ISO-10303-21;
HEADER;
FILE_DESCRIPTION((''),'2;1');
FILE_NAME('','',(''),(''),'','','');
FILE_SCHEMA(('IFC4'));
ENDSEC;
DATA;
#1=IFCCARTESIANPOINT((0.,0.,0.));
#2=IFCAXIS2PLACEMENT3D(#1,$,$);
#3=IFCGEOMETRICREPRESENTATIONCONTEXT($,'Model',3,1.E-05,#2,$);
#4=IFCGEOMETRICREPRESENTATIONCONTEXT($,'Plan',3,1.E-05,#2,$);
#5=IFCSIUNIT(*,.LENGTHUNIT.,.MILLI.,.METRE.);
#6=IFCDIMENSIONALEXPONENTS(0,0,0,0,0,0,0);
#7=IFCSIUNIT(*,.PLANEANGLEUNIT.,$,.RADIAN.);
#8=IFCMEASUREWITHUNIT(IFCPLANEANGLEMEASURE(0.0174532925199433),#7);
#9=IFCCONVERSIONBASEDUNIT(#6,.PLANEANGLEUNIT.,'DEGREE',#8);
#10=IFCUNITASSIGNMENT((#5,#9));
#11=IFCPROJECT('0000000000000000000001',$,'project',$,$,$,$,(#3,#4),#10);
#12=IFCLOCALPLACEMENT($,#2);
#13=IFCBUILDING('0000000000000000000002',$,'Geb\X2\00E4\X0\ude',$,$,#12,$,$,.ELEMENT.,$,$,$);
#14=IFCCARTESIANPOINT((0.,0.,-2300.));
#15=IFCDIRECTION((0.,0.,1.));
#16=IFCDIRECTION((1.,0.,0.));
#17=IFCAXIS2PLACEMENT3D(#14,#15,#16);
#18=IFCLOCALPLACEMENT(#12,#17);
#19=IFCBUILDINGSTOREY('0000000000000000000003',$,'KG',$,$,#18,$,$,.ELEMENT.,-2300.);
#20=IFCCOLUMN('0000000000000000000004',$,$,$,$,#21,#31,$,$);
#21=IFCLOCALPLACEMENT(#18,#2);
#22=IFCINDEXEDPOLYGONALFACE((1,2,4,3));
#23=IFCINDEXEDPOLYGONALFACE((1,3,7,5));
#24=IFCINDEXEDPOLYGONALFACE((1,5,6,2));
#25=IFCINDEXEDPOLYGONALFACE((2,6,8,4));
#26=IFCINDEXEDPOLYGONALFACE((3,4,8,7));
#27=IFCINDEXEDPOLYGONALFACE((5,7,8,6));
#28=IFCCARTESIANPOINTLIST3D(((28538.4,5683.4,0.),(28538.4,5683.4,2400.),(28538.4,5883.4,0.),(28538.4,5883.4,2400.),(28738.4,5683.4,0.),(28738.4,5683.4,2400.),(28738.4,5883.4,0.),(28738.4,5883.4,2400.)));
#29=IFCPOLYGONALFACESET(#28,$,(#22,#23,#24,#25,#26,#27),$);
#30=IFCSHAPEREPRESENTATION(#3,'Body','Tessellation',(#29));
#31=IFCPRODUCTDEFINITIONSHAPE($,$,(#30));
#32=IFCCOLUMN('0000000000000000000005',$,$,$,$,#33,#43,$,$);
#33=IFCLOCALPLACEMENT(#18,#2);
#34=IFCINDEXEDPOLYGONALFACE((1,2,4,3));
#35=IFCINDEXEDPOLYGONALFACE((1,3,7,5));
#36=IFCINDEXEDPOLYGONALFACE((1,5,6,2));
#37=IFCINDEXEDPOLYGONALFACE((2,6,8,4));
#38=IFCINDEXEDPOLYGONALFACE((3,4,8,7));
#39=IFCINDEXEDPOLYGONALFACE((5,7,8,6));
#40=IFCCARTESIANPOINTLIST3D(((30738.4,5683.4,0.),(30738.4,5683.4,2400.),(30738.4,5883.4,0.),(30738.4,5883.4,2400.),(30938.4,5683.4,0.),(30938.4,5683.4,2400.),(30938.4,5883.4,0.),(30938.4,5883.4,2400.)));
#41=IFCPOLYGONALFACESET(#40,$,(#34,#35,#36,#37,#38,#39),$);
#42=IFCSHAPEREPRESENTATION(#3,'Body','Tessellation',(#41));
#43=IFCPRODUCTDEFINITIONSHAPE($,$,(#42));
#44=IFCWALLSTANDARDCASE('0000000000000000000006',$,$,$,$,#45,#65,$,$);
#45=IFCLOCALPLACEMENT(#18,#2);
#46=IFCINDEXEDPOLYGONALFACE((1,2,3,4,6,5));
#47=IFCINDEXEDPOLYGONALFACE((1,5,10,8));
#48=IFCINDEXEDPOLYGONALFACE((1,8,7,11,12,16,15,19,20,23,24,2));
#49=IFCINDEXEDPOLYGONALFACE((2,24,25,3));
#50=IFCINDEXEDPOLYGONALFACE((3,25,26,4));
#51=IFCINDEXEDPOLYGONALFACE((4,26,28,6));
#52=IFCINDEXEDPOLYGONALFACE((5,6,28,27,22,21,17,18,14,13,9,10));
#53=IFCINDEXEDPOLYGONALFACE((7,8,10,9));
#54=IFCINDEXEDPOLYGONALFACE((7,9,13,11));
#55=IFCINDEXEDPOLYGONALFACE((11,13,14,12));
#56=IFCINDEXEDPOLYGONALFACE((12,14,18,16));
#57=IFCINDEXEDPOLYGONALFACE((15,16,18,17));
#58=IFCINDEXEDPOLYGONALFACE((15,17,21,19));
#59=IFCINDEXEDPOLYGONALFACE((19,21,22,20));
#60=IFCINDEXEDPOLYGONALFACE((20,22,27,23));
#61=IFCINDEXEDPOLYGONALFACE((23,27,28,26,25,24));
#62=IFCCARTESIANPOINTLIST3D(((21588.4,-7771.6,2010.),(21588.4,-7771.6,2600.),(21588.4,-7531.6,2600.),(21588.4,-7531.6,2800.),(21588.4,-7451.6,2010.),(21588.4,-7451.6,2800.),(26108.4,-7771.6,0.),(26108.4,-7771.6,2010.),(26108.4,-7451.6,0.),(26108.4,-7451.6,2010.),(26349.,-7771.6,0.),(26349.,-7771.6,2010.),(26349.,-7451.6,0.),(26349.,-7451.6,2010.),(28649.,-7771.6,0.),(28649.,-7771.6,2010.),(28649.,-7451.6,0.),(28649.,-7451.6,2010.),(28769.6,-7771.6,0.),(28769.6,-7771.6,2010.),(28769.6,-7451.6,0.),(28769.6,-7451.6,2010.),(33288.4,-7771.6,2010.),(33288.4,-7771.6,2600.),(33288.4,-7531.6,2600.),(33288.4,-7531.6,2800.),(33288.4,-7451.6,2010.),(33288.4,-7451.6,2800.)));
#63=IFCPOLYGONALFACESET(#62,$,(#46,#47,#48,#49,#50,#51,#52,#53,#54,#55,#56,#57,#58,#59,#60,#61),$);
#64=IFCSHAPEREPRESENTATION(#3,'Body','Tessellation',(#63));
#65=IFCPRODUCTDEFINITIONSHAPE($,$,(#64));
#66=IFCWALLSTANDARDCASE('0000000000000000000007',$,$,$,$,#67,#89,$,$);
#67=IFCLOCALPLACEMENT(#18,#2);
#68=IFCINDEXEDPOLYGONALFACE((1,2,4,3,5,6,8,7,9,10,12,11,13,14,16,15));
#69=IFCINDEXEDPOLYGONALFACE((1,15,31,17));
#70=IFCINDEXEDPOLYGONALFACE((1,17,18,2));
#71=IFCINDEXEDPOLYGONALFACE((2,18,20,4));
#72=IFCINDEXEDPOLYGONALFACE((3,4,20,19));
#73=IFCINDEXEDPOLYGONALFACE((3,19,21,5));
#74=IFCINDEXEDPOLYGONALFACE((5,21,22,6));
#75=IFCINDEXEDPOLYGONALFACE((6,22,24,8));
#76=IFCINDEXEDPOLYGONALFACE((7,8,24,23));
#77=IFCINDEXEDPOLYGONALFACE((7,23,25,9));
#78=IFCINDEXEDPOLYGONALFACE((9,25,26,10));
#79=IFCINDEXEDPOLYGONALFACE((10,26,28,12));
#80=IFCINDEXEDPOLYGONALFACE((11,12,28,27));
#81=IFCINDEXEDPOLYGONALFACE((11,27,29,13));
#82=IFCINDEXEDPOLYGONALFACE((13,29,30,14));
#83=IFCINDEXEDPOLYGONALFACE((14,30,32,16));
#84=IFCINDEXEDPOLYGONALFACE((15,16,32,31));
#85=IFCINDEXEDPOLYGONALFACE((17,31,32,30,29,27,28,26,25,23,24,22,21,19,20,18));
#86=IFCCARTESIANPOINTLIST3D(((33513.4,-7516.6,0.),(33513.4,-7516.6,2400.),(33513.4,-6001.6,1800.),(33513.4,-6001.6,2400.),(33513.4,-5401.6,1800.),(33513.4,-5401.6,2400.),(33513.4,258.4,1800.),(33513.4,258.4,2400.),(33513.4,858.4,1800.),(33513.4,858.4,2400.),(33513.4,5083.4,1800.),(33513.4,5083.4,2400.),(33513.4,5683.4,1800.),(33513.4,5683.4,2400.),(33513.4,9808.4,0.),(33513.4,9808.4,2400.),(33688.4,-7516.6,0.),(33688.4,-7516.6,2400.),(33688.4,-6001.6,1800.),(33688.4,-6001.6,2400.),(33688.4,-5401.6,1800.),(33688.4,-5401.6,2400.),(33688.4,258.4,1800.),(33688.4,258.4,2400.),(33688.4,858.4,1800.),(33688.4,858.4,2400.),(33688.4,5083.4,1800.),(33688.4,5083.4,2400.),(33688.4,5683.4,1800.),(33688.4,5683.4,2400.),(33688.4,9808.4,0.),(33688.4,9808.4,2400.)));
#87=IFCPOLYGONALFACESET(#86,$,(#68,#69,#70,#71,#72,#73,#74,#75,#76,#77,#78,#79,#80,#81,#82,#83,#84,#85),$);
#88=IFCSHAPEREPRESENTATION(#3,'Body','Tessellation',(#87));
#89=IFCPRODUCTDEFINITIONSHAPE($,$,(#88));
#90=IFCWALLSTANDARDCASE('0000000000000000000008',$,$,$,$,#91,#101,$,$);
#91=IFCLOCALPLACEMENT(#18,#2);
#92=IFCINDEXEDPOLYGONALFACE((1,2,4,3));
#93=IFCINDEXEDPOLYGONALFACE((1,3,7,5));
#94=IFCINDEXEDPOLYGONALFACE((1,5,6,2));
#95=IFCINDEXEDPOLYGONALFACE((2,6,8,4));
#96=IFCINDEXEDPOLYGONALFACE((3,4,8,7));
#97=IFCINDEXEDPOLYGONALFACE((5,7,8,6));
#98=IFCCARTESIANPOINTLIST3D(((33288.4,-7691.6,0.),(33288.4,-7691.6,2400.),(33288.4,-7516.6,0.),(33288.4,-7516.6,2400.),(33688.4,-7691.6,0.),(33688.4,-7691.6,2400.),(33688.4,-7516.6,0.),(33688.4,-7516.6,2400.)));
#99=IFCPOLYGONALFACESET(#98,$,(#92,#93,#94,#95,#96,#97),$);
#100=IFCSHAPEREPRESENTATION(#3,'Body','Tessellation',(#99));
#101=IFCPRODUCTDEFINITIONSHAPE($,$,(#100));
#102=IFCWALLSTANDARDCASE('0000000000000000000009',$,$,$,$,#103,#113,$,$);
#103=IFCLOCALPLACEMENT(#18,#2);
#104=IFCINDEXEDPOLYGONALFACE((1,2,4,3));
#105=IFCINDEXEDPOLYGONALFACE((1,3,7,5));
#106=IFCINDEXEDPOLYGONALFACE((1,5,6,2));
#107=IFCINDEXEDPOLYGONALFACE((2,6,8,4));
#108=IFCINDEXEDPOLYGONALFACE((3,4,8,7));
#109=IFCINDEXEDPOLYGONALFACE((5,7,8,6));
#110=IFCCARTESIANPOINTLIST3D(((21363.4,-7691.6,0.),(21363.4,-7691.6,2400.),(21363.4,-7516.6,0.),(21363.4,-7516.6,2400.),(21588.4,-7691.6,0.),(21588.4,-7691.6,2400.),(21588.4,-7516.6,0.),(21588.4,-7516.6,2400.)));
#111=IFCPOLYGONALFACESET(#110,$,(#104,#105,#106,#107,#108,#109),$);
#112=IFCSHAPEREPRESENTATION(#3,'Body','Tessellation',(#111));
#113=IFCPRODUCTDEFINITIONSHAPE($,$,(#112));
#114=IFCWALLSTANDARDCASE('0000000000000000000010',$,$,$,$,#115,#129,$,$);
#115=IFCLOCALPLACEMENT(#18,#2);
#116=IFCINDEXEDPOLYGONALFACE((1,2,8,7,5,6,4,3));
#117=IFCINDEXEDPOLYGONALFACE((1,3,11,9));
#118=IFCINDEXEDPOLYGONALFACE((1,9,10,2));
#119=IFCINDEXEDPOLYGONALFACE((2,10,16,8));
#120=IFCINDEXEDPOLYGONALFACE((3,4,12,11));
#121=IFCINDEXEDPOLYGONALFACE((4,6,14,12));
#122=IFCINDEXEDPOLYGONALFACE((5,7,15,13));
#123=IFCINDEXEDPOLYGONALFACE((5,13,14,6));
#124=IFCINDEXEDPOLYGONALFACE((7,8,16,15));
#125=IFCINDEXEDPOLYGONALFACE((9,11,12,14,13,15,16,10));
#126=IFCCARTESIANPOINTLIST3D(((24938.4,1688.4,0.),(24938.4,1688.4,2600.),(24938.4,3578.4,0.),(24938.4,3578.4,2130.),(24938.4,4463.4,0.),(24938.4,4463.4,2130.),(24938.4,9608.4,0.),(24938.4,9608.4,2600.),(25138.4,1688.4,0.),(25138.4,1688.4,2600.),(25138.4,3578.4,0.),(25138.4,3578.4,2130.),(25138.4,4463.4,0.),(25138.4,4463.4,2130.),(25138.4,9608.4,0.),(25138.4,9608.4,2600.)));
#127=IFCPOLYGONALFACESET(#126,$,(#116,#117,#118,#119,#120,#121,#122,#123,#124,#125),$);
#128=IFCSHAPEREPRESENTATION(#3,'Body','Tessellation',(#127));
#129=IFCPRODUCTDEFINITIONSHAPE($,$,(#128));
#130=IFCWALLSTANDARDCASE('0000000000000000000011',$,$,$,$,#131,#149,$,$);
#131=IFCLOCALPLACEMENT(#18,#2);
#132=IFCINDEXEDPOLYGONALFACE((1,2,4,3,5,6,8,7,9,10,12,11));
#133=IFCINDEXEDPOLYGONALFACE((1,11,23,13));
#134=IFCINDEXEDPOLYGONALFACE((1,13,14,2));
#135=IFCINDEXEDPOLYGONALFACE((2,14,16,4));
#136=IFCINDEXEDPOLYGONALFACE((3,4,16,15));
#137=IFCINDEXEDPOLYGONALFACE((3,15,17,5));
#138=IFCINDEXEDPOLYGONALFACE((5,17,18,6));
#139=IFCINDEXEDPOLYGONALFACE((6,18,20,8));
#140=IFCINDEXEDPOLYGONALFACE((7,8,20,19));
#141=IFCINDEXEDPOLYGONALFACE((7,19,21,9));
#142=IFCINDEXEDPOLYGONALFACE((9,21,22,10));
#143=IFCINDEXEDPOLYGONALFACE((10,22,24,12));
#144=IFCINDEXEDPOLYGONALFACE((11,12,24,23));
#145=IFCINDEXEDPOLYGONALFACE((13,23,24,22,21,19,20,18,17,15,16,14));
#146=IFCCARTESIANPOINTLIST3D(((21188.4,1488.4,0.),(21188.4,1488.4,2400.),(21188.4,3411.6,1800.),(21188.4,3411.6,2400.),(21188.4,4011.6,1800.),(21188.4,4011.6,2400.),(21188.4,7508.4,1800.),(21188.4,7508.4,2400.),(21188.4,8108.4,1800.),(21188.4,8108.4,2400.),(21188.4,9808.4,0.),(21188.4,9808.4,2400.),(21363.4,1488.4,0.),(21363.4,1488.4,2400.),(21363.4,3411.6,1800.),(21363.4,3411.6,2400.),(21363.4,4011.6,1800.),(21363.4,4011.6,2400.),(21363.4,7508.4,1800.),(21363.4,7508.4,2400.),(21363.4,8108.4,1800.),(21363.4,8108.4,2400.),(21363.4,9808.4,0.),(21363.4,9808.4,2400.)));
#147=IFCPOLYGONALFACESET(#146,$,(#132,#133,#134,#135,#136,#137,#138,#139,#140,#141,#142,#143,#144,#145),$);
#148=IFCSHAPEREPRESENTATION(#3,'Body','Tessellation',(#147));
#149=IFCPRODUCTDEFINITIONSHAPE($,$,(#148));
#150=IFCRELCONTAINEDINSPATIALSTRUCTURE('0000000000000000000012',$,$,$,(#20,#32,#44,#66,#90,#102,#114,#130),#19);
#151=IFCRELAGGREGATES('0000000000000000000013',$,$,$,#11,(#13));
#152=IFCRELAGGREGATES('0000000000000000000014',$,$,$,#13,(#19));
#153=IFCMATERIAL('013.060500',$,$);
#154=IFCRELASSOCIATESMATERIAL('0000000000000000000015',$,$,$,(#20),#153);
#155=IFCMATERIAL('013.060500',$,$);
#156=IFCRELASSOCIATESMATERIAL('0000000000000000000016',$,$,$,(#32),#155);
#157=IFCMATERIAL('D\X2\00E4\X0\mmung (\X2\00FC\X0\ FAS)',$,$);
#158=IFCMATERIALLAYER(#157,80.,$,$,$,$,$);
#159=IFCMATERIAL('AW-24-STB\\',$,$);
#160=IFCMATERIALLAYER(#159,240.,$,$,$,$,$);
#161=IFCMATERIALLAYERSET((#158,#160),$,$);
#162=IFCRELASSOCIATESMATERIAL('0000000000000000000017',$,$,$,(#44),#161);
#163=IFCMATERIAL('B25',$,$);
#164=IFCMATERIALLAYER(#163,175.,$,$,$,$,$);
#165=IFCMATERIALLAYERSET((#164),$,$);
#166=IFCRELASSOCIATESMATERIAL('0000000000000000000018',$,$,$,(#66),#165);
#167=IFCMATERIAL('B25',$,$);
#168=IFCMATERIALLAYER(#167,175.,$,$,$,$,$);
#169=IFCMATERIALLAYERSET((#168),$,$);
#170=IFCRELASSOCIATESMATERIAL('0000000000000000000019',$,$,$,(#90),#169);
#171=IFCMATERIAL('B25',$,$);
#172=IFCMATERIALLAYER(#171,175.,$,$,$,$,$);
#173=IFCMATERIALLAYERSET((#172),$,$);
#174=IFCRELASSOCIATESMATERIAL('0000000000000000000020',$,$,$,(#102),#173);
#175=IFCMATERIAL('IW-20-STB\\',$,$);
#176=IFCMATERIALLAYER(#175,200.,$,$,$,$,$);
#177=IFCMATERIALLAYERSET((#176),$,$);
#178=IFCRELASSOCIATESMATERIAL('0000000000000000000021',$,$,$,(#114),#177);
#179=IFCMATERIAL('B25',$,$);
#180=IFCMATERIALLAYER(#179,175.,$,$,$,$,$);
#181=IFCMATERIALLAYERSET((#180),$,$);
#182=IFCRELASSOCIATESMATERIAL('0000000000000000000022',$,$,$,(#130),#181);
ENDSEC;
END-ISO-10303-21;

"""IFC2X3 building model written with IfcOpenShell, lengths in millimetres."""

from ifc_helpers import new_model, entity, si_unit, converted_unit, frame, frame_2d, origin, origin_with_axes, place, context, project, spatial, polyline, rectangle, extrude, clip, bounded_halfspace, material, layer, layer_set, layer_usage, element, save


model = new_model("IFC2X3")

# Units and contexts
model_context = context("Model", 3, precision=1e-05, world=origin())
plan_context = context("Plan", 3, precision=1e-05, world=origin())
ifc_project = project(units=[si_unit("LENGTHUNIT", "METRE", prefix="MILLI"), converted_unit("PLANEANGLEUNIT", "DEGREE", entity("IfcPlaneAngleMeasure", 0.0174532925199433), si_unit("PLANEANGLEUNIT", "RADIAN"), dimensions=[0, 0, 0, 0, 0, 0, 0])], contexts=[model_context, plan_context])

# Building, storey
building_placement = place(None, origin())
building = spatial("IfcBuilding", under=ifc_project, at=building_placement, Name="Gebäude", CompositionType="ELEMENT")
storey_placement = place(building_placement, frame((0.0, 0.0, -2300.0), z_axis=(0.0, 0.0, 1.0), x_axis=(1.0, 0.0, 0.0)))
storey = spatial("IfcBuildingStorey", under=building, at=storey_placement, Name="KG", CompositionType="ELEMENT", Elevation=-2300.0)

# Columns
ifc_material_1 = material(Name="013.060500")
column_1_placement = place(storey_placement, frame((28538.4, 5683.4, 0.0), z_axis=(0.0, 0.0, 1.0), x_axis=(1.0, 0.0, 0.0)))
element("IfcColumn", 1, at=column_1_placement, inside=storey, material=ifc_material_1, context=model_context, shape_type="SweptSolid", body=[
    extrude(rectangle(XDim=200.0, YDim=200.0, at=frame_2d((100.0, 100.0), x_axis=(1.0, 0.0))), origin_with_axes(), (0.0, 0.0, 1.0), 2400.0),
])
ifc_material_2 = material(Name="013.060500")
column_2_placement = place(storey_placement, frame((30738.4, 5683.4, 0.0), z_axis=(0.0, 0.0, 1.0), x_axis=(1.0, 0.0, 0.0)))
element("IfcColumn", 2, at=column_2_placement, inside=storey, material=ifc_material_2, context=model_context, shape_type="SweptSolid", body=[
    extrude(rectangle(XDim=200.0, YDim=200.0, at=frame_2d((100.0, 100.0), x_axis=(1.0, 0.0))), origin_with_axes(), (0.0, 0.0, 1.0), 2400.0),
])

# Walls, openings
ifc_material_3 = material(Name="Dämmung (ü FAS)")
ifc_layer_1 = layer(ifc_material_3, 80.0)
ifc_material_4 = material(Name="AW-24-STB\\")
ifc_layer_2 = layer(ifc_material_4, 240.0)
ifc_layer_set_1 = layer_set([ifc_layer_1, ifc_layer_2])
ifc_layer_usage_1 = layer_usage(ifc_layer_set_1, "AXIS2", "POSITIVE", 0.0)
wall_1_placement = place(storey_placement, frame((33288.4, -7451.6, 0.0), z_axis=(0.0, 0.0, 1.0), x_axis=(-1.0, 0.0, 0.0)))
wall_1 = element("IfcWallStandardCase", 3, at=wall_1_placement, inside=storey, material=ifc_layer_usage_1, context=model_context, shape_type="Clipping", body=[
    clip(clip(extrude(rectangle(XDim=11700.0, YDim=320.0, at=frame_2d((5850.0, 160.0), x_axis=(1.0, 0.0))), origin_with_axes(), (0.0, 0.0, 1.0), 2800.0), bounded_halfspace(frame((0.0, 0.0, 2800.0), z_axis=(0.0, 0.0, -1.0), x_axis=(1.0, 0.0, 0.0)), True, origin(), polyline([(0.0, 0.0), (11700.0, 0.0), (11700.0, 80.0), (0.0, 80.0), (0.0, 0.0)]))), bounded_halfspace(frame((0.0, 80.0, 2600.0), z_axis=(0.0, 0.0, -1.0), x_axis=(1.0, 0.0, 0.0)), True, origin(), polyline([(0.0, 80.0), (11700.0, 80.0), (11700.0, 320.0), (0.0, 320.0), (0.0, 80.0)]))),
])
opening_1_placement = place(wall_1_placement, frame((4639.3, 0.0, 0.0), z_axis=(0.0, 1.0, 0.0), x_axis=(0.0, 0.0, 1.0)))
element("IfcOpeningElement", 4, at=opening_1_placement, cuts=wall_1, ObjectType="Opening", context=model_context, shape_type="SweptSolid", body=[
    extrude(rectangle(XDim=2010.0, YDim=2300.0, at=frame_2d((1005.0, 1150.0), x_axis=(1.0, 0.0))), origin_with_axes(), (0.0, 0.0, 1.0), 320.0),
])
opening_2_placement = place(wall_1_placement, frame((7180.0, 0.0, 0.0), z_axis=(0.0, 1.0, 0.0), x_axis=(0.0, 0.0, 1.0)))
element("IfcOpeningElement", 5, at=opening_2_placement, cuts=wall_1, ObjectType="Opening", context=model_context, shape_type="SweptSolid", body=[
    extrude(rectangle(XDim=2010.0, YDim=4520.0, at=frame_2d((1005.0, 2260.0), x_axis=(1.0, 0.0))), origin_with_axes(), (0.0, 0.0, 1.0), 320.0),
])
opening_3_placement = place(wall_1_placement, frame((0.0, 0.0, 0.0), z_axis=(0.0, 1.0, 0.0), x_axis=(0.0, 0.0, 1.0)))
element("IfcOpeningElement", 6, at=opening_3_placement, cuts=wall_1, ObjectType="Opening", context=model_context, shape_type="SweptSolid", body=[
    extrude(rectangle(XDim=2010.0, YDim=4518.8, at=frame_2d((1005.0, 2259.4), x_axis=(1.0, 0.0))), origin_with_axes(), (0.0, 0.0, 1.0), 320.0),
])
ifc_material_5 = material(Name="B25")
ifc_layer_3 = layer(ifc_material_5, 175.0)
ifc_layer_set_2 = layer_set([ifc_layer_3])
ifc_layer_usage_2 = layer_usage(ifc_layer_set_2, "AXIS2", "POSITIVE", 0.0)
wall_2_placement = place(storey_placement, frame((33688.4, -7516.6, 0.0), z_axis=(0.0, 0.0, 1.0), x_axis=(0.0, 1.0, 0.0)))
wall_2 = element("IfcWallStandardCase", 7, at=wall_2_placement, inside=storey, material=ifc_layer_usage_2, context=model_context, shape_type="SweptSolid", body=[
    extrude(rectangle(XDim=17325.0, YDim=175.0, at=frame_2d((8662.5, 87.5), x_axis=(1.0, 0.0))), origin_with_axes(), (0.0, 0.0, 1.0), 2400.0),
])
opening_4_placement = place(wall_2_placement, frame((12600.0, 0.0, 1800.0), z_axis=(0.0, 1.0, 0.0), x_axis=(0.0, 0.0, 1.0)))
element("IfcOpeningElement", 8, at=opening_4_placement, cuts=wall_2, ObjectType="Opening", context=model_context, shape_type="SweptSolid", body=[
    extrude(rectangle(XDim=600.0, YDim=600.0, at=frame_2d((300.0, 300.0), x_axis=(1.0, 0.0))), origin_with_axes(), (0.0, 0.0, 1.0), 175.0),
])
opening_5_placement = place(wall_2_placement, frame((1515.0, 0.0, 1800.0), z_axis=(0.0, 1.0, 0.0), x_axis=(0.0, 0.0, 1.0)))
element("IfcOpeningElement", 9, at=opening_5_placement, cuts=wall_2, ObjectType="Opening", context=model_context, shape_type="SweptSolid", body=[
    extrude(rectangle(XDim=600.0, YDim=600.0, at=frame_2d((300.0, 300.0), x_axis=(1.0, 0.0))), origin_with_axes(), (0.0, 0.0, 1.0), 175.0),
])
opening_6_placement = place(wall_2_placement, frame((7775.0, 0.0, 1800.0), z_axis=(0.0, 1.0, 0.0), x_axis=(0.0, 0.0, 1.0)))
element("IfcOpeningElement", 10, at=opening_6_placement, cuts=wall_2, ObjectType="Opening", context=model_context, shape_type="SweptSolid", body=[
    extrude(rectangle(XDim=600.0, YDim=600.0, at=frame_2d((300.0, 300.0), x_axis=(1.0, 0.0))), origin_with_axes(), (0.0, 0.0, 1.0), 175.0),
])

# Walls
ifc_material_6 = material(Name="B25")
ifc_layer_4 = layer(ifc_material_6, 175.0)
ifc_layer_set_3 = layer_set([ifc_layer_4])
ifc_layer_usage_3 = layer_usage(ifc_layer_set_3, "AXIS2", "POSITIVE", 0.0)
wall_3_placement = place(storey_placement, frame((33288.4, -7691.6, 0.0), z_axis=(0.0, 0.0, 1.0), x_axis=(1.0, 0.0, 0.0)))
element("IfcWallStandardCase", 11, at=wall_3_placement, inside=storey, material=ifc_layer_usage_3, context=model_context, shape_type="SweptSolid", body=[
    extrude(rectangle(XDim=400.0, YDim=175.0, at=frame_2d((200.0, 87.5), x_axis=(1.0, 0.0))), origin_with_axes(), (0.0, 0.0, 1.0), 2400.0),
])
ifc_material_7 = material(Name="B25")
ifc_layer_5 = layer(ifc_material_7, 175.0)
ifc_layer_set_4 = layer_set([ifc_layer_5])
ifc_layer_usage_4 = layer_usage(ifc_layer_set_4, "AXIS2", "POSITIVE", 0.0)
wall_4_placement = place(storey_placement, frame((21363.4, -7691.6, 0.0), z_axis=(0.0, 0.0, 1.0), x_axis=(1.0, 0.0, 0.0)))
element("IfcWallStandardCase", 12, at=wall_4_placement, inside=storey, material=ifc_layer_usage_4, context=model_context, shape_type="SweptSolid", body=[
    extrude(rectangle(XDim=225.0, YDim=175.0, at=frame_2d((112.5, 87.5), x_axis=(1.0, 0.0))), origin_with_axes(), (0.0, 0.0, 1.0), 2400.0),
])

# Wall, opening
ifc_material_8 = material(Name="IW-20-STB\\")
ifc_layer_6 = layer(ifc_material_8, 200.0)
ifc_layer_set_5 = layer_set([ifc_layer_6])
ifc_layer_usage_5 = layer_usage(ifc_layer_set_5, "AXIS2", "POSITIVE", -200.0)
wall_5_placement = place(storey_placement, frame((24938.4, 9608.4, 0.0), z_axis=(0.0, 0.0, 1.0), x_axis=(0.0, -1.0, 0.0)))
wall_5 = element("IfcWallStandardCase", 13, at=wall_5_placement, inside=storey, material=ifc_layer_usage_5, context=model_context, shape_type="SweptSolid", body=[
    extrude(rectangle(XDim=7920.0, YDim=200.0, at=frame_2d((3960.0, 100.0), x_axis=(1.0, 0.0))), origin_with_axes(), (0.0, 0.0, 1.0), 2600.0),
])
opening_7_placement = place(wall_5_placement, frame((5145.0, 0.0, 0.0), z_axis=(0.0, 1.0, 0.0), x_axis=(0.0, 0.0, 1.0)))
element("IfcOpeningElement", 14, at=opening_7_placement, cuts=wall_5, ObjectType="Opening", context=model_context, shape_type="SweptSolid", body=[
    extrude(rectangle(XDim=2130.0, YDim=885.0, at=frame_2d((1065.0, 442.5), x_axis=(1.0, 0.0))), origin_with_axes(), (0.0, 0.0, 1.0), 200.0),
])

# Wall, openings
ifc_material_9 = material(Name="B25")
ifc_layer_7 = layer(ifc_material_9, 175.0)
ifc_layer_set_6 = layer_set([ifc_layer_7])
ifc_layer_usage_6 = layer_usage(ifc_layer_set_6, "AXIS2", "POSITIVE", 0.0)
wall_6_placement = place(storey_placement, frame((21188.4, 9808.4, 0.0), z_axis=(0.0, 0.0, 1.0), x_axis=(0.0, -1.0, 0.0)))
wall_6 = element("IfcWallStandardCase", 15, at=wall_6_placement, inside=storey, material=ifc_layer_usage_6, context=model_context, shape_type="SweptSolid", body=[
    extrude(rectangle(XDim=8320.0, YDim=175.0, at=frame_2d((4160.0, 87.5), x_axis=(1.0, 0.0))), origin_with_axes(), (0.0, 0.0, 1.0), 2400.0),
])
opening_8_placement = place(wall_6_placement, frame((1700.0, 0.0, 1800.0), z_axis=(0.0, 1.0, 0.0), x_axis=(0.0, 0.0, 1.0)))
element("IfcOpeningElement", 16, at=opening_8_placement, cuts=wall_6, ObjectType="Opening", context=model_context, shape_type="SweptSolid", body=[
    extrude(rectangle(XDim=600.0, YDim=600.0, at=frame_2d((300.0, 300.0), x_axis=(1.0, 0.0))), origin_with_axes(), (0.0, 0.0, 1.0), 175.0),
])
opening_9_placement = place(wall_6_placement, frame((5796.8, 0.0, 1800.0), z_axis=(0.0, 1.0, 0.0), x_axis=(0.0, 0.0, 1.0)))
element("IfcOpeningElement", 17, at=opening_9_placement, cuts=wall_6, ObjectType="Opening", context=model_context, shape_type="SweptSolid", body=[
    extrude(rectangle(XDim=600.0, YDim=600.0, at=frame_2d((300.0, 300.0), x_axis=(1.0, 0.0))), origin_with_axes(), (0.0, 0.0, 1.0), 175.0),
])

save(model, "model.ifc")
